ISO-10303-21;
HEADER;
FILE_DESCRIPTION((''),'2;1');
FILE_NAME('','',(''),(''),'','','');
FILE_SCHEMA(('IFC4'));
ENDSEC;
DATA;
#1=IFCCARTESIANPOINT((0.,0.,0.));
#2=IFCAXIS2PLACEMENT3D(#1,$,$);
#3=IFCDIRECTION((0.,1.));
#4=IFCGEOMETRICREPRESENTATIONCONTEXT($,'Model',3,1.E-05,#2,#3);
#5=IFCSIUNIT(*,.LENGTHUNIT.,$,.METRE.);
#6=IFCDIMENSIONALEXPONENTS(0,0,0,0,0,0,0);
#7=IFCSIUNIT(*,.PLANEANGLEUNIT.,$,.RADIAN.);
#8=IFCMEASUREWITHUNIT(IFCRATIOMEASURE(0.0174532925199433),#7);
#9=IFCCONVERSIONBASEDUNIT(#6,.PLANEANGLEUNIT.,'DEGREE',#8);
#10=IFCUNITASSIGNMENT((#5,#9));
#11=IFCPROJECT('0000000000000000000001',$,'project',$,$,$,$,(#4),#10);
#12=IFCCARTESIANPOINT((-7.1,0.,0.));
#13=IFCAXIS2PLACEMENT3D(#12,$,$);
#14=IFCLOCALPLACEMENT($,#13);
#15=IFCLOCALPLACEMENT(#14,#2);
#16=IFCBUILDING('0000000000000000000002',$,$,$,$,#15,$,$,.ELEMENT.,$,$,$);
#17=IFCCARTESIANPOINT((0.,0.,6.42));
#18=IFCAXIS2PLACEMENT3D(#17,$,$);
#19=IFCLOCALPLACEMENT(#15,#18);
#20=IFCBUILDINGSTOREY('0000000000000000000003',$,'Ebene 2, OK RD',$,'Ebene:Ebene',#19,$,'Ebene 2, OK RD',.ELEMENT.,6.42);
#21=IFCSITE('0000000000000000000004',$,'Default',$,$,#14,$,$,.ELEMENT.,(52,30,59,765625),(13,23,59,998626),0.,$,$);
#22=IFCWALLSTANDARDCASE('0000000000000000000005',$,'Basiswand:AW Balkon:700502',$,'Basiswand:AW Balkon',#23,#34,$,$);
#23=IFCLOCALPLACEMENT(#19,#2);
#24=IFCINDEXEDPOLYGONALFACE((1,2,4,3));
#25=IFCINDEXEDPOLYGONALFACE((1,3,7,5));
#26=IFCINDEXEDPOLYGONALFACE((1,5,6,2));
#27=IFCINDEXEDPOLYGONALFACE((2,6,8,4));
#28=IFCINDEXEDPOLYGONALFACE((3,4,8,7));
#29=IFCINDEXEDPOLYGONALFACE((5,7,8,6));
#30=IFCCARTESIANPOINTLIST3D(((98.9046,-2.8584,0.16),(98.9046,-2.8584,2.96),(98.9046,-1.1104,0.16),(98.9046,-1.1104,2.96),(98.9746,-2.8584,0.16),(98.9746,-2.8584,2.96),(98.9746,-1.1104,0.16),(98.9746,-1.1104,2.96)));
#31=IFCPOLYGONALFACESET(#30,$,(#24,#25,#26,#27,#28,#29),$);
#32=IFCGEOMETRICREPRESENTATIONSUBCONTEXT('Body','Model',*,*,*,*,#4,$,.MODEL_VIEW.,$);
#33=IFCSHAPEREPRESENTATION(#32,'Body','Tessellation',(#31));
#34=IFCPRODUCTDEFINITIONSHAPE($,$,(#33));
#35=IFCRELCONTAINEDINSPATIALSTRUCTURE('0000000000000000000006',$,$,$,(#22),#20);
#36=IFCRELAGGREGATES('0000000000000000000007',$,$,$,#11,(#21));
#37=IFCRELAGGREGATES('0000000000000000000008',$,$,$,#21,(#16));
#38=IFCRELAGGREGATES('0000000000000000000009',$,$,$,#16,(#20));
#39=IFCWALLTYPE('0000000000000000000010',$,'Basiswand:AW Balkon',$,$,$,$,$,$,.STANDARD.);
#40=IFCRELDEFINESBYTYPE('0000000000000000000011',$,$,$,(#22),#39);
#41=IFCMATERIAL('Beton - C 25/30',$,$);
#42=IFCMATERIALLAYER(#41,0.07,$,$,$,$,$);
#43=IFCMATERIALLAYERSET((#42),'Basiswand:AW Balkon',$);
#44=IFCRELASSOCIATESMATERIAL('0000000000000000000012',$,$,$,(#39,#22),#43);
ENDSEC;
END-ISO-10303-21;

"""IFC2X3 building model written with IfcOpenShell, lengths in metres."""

from ifc_helpers import new_model, entity, si_unit, converted_unit, direction, frame, frame_2d, origin, place, context, subcontext, project, spatial, rectangle, extrude, material, layer, layer_set, layer_usage, type_object, element, save


model = new_model("IFC2X3")

# Units and contexts
model_context = context("Model", 3, precision=1e-05, world=origin(), true_north=direction((0.0, 1.0)))
body_context = subcontext(model_context, "Body", "Model", "MODEL_VIEW")
ifc_project = project(units=[si_unit("LENGTHUNIT", "METRE"), converted_unit("PLANEANGLEUNIT", "DEGREE", entity("IfcRatioMeasure", 0.0174532925199433), si_unit("PLANEANGLEUNIT", "RADIAN"), dimensions=[0, 0, 0, 0, 0, 0, 0])], contexts=[model_context])

# Site, building, storey
site_placement = place(None, frame((-7.1, 0.0, 0.0)))
site = spatial("IfcSite", under=ifc_project, at=site_placement, Name="Default", CompositionType="ELEMENT", RefLatitude=(52, 30, 59, 765625), RefLongitude=(13, 23, 59, 998626), RefElevation=0.0)
building_placement = place(site_placement, origin())
building = spatial("IfcBuilding", under=site, at=building_placement, CompositionType="ELEMENT")
storey_placement = place(building_placement, frame((0.0, 0.0, 6.42)))
storey = spatial("IfcBuildingStorey", under=building, at=storey_placement, Name="Ebene 2, OK RD", ObjectType="Ebene:Ebene", LongName="Ebene 2, OK RD", CompositionType="ELEMENT", Elevation=6.42)

# Wall
ifc_material_1 = material(Name="Beton - C 25/30")
ifc_layer_1 = layer(ifc_material_1, 0.07)
ifc_layer_set_1 = layer_set([ifc_layer_1], Name="Basiswand:AW Balkon")
wall_type_1 = type_object("IfcWallType", Name="Basiswand:AW Balkon", PredefinedType="STANDARD", material=ifc_layer_set_1)
ifc_layer_usage_1 = layer_usage(ifc_layer_set_1, "AXIS2", "NEGATIVE", 0.035)
wall_1_placement = place(storey_placement, frame((98.9396, -2.8584, 0.16), z_axis=(0.0, 0.0, 1.0), x_axis=(0.0, 1.0, 0.0)))
element("IfcWallStandardCase", 1, at=wall_1_placement, inside=storey, type_object=wall_type_1, material=ifc_layer_usage_1, Name="Basiswand:AW Balkon:700502", ObjectType="Basiswand:AW Balkon", context=body_context, shape_type="SweptSolid", body=[
    extrude(rectangle(XDim=1.748, YDim=0.07, at=frame_2d((0.874, 0.0), x_axis=(-1.0, 0.0))), origin(), (0.0, 0.0, 1.0), 2.8),
])

save(model, "model.ifc")
